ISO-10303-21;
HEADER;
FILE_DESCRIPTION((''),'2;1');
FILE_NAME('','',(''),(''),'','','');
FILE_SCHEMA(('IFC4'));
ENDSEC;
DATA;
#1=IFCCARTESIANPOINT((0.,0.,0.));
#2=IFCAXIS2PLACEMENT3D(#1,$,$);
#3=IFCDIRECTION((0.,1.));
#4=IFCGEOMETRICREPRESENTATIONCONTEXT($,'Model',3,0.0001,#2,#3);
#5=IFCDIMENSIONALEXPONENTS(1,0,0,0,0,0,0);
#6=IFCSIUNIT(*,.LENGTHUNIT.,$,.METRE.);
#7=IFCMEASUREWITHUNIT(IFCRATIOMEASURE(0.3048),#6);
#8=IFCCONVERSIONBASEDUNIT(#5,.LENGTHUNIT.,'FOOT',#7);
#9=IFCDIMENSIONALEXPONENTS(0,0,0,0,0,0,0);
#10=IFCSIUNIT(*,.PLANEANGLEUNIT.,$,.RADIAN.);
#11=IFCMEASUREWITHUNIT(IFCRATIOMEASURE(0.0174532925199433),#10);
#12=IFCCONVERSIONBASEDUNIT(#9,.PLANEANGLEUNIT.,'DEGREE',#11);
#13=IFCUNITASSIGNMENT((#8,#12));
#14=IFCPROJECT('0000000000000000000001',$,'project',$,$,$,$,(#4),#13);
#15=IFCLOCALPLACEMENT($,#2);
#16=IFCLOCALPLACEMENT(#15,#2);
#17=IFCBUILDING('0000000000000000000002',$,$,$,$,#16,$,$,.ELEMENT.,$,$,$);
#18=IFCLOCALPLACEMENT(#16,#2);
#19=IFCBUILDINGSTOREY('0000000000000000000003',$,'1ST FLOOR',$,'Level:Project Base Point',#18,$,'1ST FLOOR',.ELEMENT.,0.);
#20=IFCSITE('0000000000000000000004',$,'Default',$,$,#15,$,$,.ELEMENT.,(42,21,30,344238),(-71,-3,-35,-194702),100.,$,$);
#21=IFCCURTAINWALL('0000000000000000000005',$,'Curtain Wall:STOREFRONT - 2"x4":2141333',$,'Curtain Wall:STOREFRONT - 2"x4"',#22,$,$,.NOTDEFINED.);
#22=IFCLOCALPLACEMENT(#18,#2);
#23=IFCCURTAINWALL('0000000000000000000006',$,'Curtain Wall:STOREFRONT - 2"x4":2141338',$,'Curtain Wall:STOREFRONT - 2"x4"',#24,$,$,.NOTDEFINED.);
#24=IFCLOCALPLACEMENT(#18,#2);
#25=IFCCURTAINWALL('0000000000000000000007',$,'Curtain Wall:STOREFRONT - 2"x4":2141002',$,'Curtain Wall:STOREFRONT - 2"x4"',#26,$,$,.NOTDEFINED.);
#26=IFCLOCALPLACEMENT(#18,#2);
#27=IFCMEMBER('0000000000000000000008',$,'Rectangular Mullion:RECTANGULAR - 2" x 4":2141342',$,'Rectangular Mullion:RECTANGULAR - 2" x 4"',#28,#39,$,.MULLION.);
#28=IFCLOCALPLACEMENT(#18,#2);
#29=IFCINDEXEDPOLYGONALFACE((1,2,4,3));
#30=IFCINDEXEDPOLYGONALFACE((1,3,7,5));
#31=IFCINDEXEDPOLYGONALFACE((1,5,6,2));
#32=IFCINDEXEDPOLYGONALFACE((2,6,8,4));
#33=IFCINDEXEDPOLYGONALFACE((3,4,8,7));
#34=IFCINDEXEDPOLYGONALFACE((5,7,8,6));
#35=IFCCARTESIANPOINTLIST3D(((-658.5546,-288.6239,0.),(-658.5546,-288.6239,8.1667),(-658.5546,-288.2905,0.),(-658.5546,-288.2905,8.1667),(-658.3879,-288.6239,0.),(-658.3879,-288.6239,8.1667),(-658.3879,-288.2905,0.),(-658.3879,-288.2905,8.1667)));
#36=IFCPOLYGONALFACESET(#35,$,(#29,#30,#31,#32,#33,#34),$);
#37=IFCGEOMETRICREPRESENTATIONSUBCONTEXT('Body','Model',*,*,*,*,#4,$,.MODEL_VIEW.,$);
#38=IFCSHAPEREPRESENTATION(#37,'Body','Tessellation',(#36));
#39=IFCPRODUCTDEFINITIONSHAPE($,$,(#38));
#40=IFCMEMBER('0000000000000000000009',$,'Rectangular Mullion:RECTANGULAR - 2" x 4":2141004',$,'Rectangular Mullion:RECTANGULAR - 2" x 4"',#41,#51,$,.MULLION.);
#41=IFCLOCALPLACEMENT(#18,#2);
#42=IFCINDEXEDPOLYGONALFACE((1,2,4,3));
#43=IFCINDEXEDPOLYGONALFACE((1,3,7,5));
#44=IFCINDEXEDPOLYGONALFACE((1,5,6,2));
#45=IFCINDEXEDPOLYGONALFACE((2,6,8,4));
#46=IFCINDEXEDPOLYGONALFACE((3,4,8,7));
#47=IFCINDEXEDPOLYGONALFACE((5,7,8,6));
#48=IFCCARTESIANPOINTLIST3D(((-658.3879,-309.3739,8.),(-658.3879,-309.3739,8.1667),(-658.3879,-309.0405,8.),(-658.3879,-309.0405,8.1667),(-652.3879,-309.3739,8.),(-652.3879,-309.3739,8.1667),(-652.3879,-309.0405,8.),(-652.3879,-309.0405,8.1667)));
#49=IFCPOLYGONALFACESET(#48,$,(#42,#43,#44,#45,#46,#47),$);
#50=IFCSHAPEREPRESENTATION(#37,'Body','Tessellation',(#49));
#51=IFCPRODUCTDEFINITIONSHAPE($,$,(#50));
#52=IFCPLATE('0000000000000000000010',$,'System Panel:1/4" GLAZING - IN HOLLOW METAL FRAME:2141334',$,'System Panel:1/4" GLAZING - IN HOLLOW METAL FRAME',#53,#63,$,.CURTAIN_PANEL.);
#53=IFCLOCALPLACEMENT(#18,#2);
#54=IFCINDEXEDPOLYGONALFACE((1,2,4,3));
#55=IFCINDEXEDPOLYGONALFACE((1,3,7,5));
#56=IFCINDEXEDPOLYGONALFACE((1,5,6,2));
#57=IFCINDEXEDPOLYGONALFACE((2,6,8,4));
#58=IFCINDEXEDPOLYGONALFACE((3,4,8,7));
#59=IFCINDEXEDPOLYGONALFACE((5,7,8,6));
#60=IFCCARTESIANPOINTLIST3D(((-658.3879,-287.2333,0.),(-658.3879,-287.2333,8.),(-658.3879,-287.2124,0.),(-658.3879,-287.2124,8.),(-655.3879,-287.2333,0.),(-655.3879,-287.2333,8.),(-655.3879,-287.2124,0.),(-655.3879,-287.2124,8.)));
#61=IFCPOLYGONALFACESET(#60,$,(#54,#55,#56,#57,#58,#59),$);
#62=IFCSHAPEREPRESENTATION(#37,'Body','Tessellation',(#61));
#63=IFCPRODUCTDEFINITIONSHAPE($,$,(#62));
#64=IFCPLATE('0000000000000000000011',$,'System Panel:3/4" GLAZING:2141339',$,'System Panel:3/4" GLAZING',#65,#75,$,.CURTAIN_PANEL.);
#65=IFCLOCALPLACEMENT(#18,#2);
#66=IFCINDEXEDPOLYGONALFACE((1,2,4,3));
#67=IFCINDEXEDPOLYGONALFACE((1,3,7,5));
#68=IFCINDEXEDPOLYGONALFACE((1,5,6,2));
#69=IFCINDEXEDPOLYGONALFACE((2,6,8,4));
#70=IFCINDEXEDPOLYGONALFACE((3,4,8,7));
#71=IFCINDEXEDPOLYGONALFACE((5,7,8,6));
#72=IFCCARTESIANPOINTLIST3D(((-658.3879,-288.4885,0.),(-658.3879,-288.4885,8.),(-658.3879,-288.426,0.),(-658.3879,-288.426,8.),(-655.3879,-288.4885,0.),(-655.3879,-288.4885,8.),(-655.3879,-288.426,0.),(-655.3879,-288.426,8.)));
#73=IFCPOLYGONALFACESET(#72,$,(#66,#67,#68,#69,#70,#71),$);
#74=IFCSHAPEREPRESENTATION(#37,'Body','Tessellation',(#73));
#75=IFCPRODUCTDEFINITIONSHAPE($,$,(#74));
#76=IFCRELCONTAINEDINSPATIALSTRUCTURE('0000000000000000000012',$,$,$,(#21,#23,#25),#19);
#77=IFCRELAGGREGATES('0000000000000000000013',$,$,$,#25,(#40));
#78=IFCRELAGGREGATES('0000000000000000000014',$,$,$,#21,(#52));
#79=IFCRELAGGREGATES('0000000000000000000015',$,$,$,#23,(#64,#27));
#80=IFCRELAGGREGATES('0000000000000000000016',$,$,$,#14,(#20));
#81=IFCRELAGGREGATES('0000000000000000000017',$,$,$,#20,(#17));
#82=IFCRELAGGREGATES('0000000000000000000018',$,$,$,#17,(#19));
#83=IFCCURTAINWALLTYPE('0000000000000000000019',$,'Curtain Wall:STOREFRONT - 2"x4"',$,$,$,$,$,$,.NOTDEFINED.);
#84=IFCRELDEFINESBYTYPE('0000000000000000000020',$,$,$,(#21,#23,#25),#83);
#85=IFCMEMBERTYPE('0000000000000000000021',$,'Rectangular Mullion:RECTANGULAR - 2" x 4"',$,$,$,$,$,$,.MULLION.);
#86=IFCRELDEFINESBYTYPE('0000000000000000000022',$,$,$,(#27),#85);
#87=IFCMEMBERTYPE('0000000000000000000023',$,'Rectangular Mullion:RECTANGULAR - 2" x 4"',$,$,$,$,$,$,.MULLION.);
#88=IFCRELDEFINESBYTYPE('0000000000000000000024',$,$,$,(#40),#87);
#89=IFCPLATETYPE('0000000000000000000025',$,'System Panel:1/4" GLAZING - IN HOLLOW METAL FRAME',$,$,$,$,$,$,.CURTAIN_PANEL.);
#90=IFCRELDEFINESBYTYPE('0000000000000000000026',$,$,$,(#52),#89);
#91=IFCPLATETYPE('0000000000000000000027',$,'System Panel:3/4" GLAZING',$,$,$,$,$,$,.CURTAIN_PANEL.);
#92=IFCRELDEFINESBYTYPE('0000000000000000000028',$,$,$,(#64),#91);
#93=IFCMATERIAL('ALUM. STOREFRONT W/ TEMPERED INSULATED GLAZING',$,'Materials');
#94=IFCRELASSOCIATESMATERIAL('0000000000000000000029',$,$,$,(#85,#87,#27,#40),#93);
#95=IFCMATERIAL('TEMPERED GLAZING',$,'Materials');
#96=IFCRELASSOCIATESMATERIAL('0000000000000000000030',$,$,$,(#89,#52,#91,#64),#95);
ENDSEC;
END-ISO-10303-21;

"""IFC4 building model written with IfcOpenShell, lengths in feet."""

from ifc_helpers import new_model, entity, si_unit, converted_unit, direction, frame, frame_2d, origin, origin_2d_with_axis, place, context, subcontext, project, spatial, rectangle, extrude, source, transform, mapped, material, material_profile, profile_set, profile_usage, type_object, type_shapes, element, aggregate, save


model = new_model("IFC4")

# Units and contexts
model_context = context("Model", 3, precision=0.0001, world=origin(), true_north=direction((0.0, 1.0)))
body_context = subcontext(model_context, "Body", "Model", "MODEL_VIEW")
ifc_project = project(units=[converted_unit("LENGTHUNIT", "FOOT", entity("IfcRatioMeasure", 0.3048), si_unit("LENGTHUNIT", "METRE"), dimensions=[1, 0, 0, 0, 0, 0, 0]), converted_unit("PLANEANGLEUNIT", "DEGREE", entity("IfcRatioMeasure", 0.0174532925199433), si_unit("PLANEANGLEUNIT", "RADIAN"), dimensions=[0, 0, 0, 0, 0, 0, 0])], contexts=[model_context])

# Site, building, storey
site_placement = place(None, origin())
site = spatial("IfcSite", under=ifc_project, at=site_placement, Name="Default", CompositionType="ELEMENT", RefLatitude=(42, 21, 30, 344238), RefLongitude=(-71, -3, -35, -194702), RefElevation=100.0)
building_placement = place(site_placement, origin())
building = spatial("IfcBuilding", under=site, at=building_placement, CompositionType="ELEMENT")
storey_placement = place(building_placement, origin())
storey = spatial("IfcBuildingStorey", under=building, at=storey_placement, Name="1ST FLOOR", ObjectType="Level:Project Base Point", LongName="1ST FLOOR", CompositionType="ELEMENT", Elevation=0.0)

# Curtain walls
curtain_wall_type = type_object("IfcCurtainWallType", Name="Curtain Wall:STOREFRONT - 2\"x4\"", PredefinedType="NOTDEFINED")
ifc_material_1 = material(Name="ALUM. STOREFRONT W/ TEMPERED INSULATED GLAZING", Category="Materials")
ifc_material_profile = material_profile(ifc_material_1, rectangle(XDim=0.3333, YDim=0.1667, at=origin_2d_with_axis()), Name="RECTANGULAR - 2\" x 4\"")
ifc_profile_set = profile_set([ifc_material_profile], Name="RECTANGULAR - 2\" x 4\"")
curtain_wall_1_placement = place(storey_placement, origin())
curtain_wall_1 = element("IfcCurtainWall", 1, at=curtain_wall_1_placement, inside=storey, type_object=curtain_wall_type, Name="Curtain Wall:STOREFRONT - 2\"x4\":2141333", ObjectType="Curtain Wall:STOREFRONT - 2\"x4\"", PredefinedType="NOTDEFINED")
curtain_wall_2_placement = place(storey_placement, origin())
curtain_wall_2 = element("IfcCurtainWall", 2, at=curtain_wall_2_placement, inside=storey, type_object=curtain_wall_type, Name="Curtain Wall:STOREFRONT - 2\"x4\":2141338", ObjectType="Curtain Wall:STOREFRONT - 2\"x4\"", PredefinedType="NOTDEFINED")

# Curtain wall
curtain_wall_3_placement = place(storey_placement, origin())
curtain_wall_3 = element("IfcCurtainWall", 3, at=curtain_wall_3_placement, inside=storey, type_object=curtain_wall_type, Name="Curtain Wall:STOREFRONT - 2\"x4\":2141002", ObjectType="Curtain Wall:STOREFRONT - 2\"x4\"", PredefinedType="NOTDEFINED")

# Members
member_type_1 = type_object("IfcMemberType", Name="Rectangular Mullion:RECTANGULAR - 2\" x 4\"", PredefinedType="MULLION", material=ifc_profile_set)
shared_shape_1 = source(origin(), body_context, "Body", "SweptSolid", [
    extrude(rectangle(XDim=0.3333, YDim=0.1667, at=origin_2d_with_axis()), frame((-0.0833, 0.0, -8.1667), z_axis=(0.0, 0.0, 1.0), x_axis=(0.0, -1.0, 0.0)), (0.0, 0.0, 1.0), 8.1667),
])
type_shapes(member_type_1, [shared_shape_1])
ifc_profile_usage_1 = profile_usage(ifc_profile_set)
member_1_placement = place(storey_placement, frame((-658.5546, -288.4572, 8.1667), z_axis=(0.0, 0.0, 1.0), x_axis=(-1.0, 0.0, 0.0)))
member_1 = element("IfcMember", 4, at=member_1_placement, type_object=member_type_1, material=ifc_profile_usage_1, Name="Rectangular Mullion:RECTANGULAR - 2\" x 4\":2141342", ObjectType="Rectangular Mullion:RECTANGULAR - 2\" x 4\"", PredefinedType="MULLION", context=body_context, shape_type="MappedRepresentation", body=[
    mapped(shared_shape_1, transform((0.0, 0.0, 0.0), scale=1.0)),
])
ifc_profile_usage_2 = profile_usage(ifc_profile_set)
member_type_2 = type_object("IfcMemberType", Name="Rectangular Mullion:RECTANGULAR - 2\" x 4\"", PredefinedType="MULLION", material=ifc_profile_set)
shared_shape_2 = source(origin(), body_context, "Body", "SweptSolid", [
    extrude(rectangle(XDim=0.3333, YDim=0.1667, at=origin_2d_with_axis()), frame((-0.0833, 0.0, -6.0), z_axis=(0.0, 0.0, 1.0), x_axis=(0.0, -1.0, 0.0)), (0.0, 0.0, 1.0), 6.0),
])
type_shapes(member_type_2, [shared_shape_2])
member_2_placement = place(storey_placement, frame((-652.3879, -309.2072, 8.1667), z_axis=(1.0, 0.0, 0.0), x_axis=(0.0, 0.0, 1.0)))
member_2 = element("IfcMember", 5, at=member_2_placement, type_object=member_type_2, material=ifc_profile_usage_2, Name="Rectangular Mullion:RECTANGULAR - 2\" x 4\":2141004", ObjectType="Rectangular Mullion:RECTANGULAR - 2\" x 4\"", PredefinedType="MULLION", context=body_context, shape_type="MappedRepresentation", body=[
    mapped(shared_shape_2, transform((0.0, 0.0, 0.0), scale=1.0)),
])
aggregate(curtain_wall_3, [member_2])

# Plates
ifc_material_2 = material(Name="TEMPERED GLAZING", Category="Materials")
plate_type_1 = type_object("IfcPlateType", Name="System Panel:1/4\" GLAZING - IN HOLLOW METAL FRAME", PredefinedType="CURTAIN_PANEL", material=ifc_material_2)
shared_shape_3 = source(origin(), body_context, "Body", "SweptSolid", [
    extrude(rectangle(XDim=0.0208, YDim=3.0, at=frame_2d((0.0, 0.0), x_axis=(1.0, 0.0))), frame((1.5, 0.0104, 0.0), z_axis=(0.0, 0.0, 1.0), x_axis=(0.0, 1.0, 0.0)), (0.0, 0.0, 1.0), 8.0),
])
type_shapes(plate_type_1, [shared_shape_3])
plate_1_placement = place(curtain_wall_1_placement, frame((-658.3879, -287.2333, 0.0)))
plate_1 = element("IfcPlate", 6, at=plate_1_placement, type_object=plate_type_1, material=ifc_material_2, Name="System Panel:1/4\" GLAZING - IN HOLLOW METAL FRAME:2141334", ObjectType="System Panel:1/4\" GLAZING - IN HOLLOW METAL FRAME", PredefinedType="CURTAIN_PANEL", context=body_context, shape_type="MappedRepresentation", body=[
    mapped(shared_shape_3, transform((0.0, 0.0, 0.0), scale=1.0)),
])
aggregate(curtain_wall_1, [plate_1])
plate_type_2 = type_object("IfcPlateType", Name="System Panel:3/4\" GLAZING", PredefinedType="CURTAIN_PANEL", material=ifc_material_2)
shared_shape_4 = source(origin(), body_context, "Body", "SweptSolid", [
    extrude(rectangle(XDim=0.0625, YDim=3.0, at=origin_2d_with_axis()), frame((0.0, 0.0, 0.0), z_axis=(0.0, 0.0, 1.0), x_axis=(0.0, 1.0, 0.0)), (0.0, 0.0, 1.0), 8.0),
])
type_shapes(plate_type_2, [shared_shape_4])
plate_2_placement = place(curtain_wall_2_placement, frame((-656.8879, -288.4572, 0.0)))
plate_2 = element("IfcPlate", 7, at=plate_2_placement, type_object=plate_type_2, material=ifc_material_2, Name="System Panel:3/4\" GLAZING:2141339", ObjectType="System Panel:3/4\" GLAZING", PredefinedType="CURTAIN_PANEL", context=body_context, shape_type="MappedRepresentation", body=[
    mapped(shared_shape_4, transform((0.0, 0.0, 0.0), scale=1.0)),
])
aggregate(curtain_wall_2, [plate_2, member_1])

save(model, "model.ifc")
